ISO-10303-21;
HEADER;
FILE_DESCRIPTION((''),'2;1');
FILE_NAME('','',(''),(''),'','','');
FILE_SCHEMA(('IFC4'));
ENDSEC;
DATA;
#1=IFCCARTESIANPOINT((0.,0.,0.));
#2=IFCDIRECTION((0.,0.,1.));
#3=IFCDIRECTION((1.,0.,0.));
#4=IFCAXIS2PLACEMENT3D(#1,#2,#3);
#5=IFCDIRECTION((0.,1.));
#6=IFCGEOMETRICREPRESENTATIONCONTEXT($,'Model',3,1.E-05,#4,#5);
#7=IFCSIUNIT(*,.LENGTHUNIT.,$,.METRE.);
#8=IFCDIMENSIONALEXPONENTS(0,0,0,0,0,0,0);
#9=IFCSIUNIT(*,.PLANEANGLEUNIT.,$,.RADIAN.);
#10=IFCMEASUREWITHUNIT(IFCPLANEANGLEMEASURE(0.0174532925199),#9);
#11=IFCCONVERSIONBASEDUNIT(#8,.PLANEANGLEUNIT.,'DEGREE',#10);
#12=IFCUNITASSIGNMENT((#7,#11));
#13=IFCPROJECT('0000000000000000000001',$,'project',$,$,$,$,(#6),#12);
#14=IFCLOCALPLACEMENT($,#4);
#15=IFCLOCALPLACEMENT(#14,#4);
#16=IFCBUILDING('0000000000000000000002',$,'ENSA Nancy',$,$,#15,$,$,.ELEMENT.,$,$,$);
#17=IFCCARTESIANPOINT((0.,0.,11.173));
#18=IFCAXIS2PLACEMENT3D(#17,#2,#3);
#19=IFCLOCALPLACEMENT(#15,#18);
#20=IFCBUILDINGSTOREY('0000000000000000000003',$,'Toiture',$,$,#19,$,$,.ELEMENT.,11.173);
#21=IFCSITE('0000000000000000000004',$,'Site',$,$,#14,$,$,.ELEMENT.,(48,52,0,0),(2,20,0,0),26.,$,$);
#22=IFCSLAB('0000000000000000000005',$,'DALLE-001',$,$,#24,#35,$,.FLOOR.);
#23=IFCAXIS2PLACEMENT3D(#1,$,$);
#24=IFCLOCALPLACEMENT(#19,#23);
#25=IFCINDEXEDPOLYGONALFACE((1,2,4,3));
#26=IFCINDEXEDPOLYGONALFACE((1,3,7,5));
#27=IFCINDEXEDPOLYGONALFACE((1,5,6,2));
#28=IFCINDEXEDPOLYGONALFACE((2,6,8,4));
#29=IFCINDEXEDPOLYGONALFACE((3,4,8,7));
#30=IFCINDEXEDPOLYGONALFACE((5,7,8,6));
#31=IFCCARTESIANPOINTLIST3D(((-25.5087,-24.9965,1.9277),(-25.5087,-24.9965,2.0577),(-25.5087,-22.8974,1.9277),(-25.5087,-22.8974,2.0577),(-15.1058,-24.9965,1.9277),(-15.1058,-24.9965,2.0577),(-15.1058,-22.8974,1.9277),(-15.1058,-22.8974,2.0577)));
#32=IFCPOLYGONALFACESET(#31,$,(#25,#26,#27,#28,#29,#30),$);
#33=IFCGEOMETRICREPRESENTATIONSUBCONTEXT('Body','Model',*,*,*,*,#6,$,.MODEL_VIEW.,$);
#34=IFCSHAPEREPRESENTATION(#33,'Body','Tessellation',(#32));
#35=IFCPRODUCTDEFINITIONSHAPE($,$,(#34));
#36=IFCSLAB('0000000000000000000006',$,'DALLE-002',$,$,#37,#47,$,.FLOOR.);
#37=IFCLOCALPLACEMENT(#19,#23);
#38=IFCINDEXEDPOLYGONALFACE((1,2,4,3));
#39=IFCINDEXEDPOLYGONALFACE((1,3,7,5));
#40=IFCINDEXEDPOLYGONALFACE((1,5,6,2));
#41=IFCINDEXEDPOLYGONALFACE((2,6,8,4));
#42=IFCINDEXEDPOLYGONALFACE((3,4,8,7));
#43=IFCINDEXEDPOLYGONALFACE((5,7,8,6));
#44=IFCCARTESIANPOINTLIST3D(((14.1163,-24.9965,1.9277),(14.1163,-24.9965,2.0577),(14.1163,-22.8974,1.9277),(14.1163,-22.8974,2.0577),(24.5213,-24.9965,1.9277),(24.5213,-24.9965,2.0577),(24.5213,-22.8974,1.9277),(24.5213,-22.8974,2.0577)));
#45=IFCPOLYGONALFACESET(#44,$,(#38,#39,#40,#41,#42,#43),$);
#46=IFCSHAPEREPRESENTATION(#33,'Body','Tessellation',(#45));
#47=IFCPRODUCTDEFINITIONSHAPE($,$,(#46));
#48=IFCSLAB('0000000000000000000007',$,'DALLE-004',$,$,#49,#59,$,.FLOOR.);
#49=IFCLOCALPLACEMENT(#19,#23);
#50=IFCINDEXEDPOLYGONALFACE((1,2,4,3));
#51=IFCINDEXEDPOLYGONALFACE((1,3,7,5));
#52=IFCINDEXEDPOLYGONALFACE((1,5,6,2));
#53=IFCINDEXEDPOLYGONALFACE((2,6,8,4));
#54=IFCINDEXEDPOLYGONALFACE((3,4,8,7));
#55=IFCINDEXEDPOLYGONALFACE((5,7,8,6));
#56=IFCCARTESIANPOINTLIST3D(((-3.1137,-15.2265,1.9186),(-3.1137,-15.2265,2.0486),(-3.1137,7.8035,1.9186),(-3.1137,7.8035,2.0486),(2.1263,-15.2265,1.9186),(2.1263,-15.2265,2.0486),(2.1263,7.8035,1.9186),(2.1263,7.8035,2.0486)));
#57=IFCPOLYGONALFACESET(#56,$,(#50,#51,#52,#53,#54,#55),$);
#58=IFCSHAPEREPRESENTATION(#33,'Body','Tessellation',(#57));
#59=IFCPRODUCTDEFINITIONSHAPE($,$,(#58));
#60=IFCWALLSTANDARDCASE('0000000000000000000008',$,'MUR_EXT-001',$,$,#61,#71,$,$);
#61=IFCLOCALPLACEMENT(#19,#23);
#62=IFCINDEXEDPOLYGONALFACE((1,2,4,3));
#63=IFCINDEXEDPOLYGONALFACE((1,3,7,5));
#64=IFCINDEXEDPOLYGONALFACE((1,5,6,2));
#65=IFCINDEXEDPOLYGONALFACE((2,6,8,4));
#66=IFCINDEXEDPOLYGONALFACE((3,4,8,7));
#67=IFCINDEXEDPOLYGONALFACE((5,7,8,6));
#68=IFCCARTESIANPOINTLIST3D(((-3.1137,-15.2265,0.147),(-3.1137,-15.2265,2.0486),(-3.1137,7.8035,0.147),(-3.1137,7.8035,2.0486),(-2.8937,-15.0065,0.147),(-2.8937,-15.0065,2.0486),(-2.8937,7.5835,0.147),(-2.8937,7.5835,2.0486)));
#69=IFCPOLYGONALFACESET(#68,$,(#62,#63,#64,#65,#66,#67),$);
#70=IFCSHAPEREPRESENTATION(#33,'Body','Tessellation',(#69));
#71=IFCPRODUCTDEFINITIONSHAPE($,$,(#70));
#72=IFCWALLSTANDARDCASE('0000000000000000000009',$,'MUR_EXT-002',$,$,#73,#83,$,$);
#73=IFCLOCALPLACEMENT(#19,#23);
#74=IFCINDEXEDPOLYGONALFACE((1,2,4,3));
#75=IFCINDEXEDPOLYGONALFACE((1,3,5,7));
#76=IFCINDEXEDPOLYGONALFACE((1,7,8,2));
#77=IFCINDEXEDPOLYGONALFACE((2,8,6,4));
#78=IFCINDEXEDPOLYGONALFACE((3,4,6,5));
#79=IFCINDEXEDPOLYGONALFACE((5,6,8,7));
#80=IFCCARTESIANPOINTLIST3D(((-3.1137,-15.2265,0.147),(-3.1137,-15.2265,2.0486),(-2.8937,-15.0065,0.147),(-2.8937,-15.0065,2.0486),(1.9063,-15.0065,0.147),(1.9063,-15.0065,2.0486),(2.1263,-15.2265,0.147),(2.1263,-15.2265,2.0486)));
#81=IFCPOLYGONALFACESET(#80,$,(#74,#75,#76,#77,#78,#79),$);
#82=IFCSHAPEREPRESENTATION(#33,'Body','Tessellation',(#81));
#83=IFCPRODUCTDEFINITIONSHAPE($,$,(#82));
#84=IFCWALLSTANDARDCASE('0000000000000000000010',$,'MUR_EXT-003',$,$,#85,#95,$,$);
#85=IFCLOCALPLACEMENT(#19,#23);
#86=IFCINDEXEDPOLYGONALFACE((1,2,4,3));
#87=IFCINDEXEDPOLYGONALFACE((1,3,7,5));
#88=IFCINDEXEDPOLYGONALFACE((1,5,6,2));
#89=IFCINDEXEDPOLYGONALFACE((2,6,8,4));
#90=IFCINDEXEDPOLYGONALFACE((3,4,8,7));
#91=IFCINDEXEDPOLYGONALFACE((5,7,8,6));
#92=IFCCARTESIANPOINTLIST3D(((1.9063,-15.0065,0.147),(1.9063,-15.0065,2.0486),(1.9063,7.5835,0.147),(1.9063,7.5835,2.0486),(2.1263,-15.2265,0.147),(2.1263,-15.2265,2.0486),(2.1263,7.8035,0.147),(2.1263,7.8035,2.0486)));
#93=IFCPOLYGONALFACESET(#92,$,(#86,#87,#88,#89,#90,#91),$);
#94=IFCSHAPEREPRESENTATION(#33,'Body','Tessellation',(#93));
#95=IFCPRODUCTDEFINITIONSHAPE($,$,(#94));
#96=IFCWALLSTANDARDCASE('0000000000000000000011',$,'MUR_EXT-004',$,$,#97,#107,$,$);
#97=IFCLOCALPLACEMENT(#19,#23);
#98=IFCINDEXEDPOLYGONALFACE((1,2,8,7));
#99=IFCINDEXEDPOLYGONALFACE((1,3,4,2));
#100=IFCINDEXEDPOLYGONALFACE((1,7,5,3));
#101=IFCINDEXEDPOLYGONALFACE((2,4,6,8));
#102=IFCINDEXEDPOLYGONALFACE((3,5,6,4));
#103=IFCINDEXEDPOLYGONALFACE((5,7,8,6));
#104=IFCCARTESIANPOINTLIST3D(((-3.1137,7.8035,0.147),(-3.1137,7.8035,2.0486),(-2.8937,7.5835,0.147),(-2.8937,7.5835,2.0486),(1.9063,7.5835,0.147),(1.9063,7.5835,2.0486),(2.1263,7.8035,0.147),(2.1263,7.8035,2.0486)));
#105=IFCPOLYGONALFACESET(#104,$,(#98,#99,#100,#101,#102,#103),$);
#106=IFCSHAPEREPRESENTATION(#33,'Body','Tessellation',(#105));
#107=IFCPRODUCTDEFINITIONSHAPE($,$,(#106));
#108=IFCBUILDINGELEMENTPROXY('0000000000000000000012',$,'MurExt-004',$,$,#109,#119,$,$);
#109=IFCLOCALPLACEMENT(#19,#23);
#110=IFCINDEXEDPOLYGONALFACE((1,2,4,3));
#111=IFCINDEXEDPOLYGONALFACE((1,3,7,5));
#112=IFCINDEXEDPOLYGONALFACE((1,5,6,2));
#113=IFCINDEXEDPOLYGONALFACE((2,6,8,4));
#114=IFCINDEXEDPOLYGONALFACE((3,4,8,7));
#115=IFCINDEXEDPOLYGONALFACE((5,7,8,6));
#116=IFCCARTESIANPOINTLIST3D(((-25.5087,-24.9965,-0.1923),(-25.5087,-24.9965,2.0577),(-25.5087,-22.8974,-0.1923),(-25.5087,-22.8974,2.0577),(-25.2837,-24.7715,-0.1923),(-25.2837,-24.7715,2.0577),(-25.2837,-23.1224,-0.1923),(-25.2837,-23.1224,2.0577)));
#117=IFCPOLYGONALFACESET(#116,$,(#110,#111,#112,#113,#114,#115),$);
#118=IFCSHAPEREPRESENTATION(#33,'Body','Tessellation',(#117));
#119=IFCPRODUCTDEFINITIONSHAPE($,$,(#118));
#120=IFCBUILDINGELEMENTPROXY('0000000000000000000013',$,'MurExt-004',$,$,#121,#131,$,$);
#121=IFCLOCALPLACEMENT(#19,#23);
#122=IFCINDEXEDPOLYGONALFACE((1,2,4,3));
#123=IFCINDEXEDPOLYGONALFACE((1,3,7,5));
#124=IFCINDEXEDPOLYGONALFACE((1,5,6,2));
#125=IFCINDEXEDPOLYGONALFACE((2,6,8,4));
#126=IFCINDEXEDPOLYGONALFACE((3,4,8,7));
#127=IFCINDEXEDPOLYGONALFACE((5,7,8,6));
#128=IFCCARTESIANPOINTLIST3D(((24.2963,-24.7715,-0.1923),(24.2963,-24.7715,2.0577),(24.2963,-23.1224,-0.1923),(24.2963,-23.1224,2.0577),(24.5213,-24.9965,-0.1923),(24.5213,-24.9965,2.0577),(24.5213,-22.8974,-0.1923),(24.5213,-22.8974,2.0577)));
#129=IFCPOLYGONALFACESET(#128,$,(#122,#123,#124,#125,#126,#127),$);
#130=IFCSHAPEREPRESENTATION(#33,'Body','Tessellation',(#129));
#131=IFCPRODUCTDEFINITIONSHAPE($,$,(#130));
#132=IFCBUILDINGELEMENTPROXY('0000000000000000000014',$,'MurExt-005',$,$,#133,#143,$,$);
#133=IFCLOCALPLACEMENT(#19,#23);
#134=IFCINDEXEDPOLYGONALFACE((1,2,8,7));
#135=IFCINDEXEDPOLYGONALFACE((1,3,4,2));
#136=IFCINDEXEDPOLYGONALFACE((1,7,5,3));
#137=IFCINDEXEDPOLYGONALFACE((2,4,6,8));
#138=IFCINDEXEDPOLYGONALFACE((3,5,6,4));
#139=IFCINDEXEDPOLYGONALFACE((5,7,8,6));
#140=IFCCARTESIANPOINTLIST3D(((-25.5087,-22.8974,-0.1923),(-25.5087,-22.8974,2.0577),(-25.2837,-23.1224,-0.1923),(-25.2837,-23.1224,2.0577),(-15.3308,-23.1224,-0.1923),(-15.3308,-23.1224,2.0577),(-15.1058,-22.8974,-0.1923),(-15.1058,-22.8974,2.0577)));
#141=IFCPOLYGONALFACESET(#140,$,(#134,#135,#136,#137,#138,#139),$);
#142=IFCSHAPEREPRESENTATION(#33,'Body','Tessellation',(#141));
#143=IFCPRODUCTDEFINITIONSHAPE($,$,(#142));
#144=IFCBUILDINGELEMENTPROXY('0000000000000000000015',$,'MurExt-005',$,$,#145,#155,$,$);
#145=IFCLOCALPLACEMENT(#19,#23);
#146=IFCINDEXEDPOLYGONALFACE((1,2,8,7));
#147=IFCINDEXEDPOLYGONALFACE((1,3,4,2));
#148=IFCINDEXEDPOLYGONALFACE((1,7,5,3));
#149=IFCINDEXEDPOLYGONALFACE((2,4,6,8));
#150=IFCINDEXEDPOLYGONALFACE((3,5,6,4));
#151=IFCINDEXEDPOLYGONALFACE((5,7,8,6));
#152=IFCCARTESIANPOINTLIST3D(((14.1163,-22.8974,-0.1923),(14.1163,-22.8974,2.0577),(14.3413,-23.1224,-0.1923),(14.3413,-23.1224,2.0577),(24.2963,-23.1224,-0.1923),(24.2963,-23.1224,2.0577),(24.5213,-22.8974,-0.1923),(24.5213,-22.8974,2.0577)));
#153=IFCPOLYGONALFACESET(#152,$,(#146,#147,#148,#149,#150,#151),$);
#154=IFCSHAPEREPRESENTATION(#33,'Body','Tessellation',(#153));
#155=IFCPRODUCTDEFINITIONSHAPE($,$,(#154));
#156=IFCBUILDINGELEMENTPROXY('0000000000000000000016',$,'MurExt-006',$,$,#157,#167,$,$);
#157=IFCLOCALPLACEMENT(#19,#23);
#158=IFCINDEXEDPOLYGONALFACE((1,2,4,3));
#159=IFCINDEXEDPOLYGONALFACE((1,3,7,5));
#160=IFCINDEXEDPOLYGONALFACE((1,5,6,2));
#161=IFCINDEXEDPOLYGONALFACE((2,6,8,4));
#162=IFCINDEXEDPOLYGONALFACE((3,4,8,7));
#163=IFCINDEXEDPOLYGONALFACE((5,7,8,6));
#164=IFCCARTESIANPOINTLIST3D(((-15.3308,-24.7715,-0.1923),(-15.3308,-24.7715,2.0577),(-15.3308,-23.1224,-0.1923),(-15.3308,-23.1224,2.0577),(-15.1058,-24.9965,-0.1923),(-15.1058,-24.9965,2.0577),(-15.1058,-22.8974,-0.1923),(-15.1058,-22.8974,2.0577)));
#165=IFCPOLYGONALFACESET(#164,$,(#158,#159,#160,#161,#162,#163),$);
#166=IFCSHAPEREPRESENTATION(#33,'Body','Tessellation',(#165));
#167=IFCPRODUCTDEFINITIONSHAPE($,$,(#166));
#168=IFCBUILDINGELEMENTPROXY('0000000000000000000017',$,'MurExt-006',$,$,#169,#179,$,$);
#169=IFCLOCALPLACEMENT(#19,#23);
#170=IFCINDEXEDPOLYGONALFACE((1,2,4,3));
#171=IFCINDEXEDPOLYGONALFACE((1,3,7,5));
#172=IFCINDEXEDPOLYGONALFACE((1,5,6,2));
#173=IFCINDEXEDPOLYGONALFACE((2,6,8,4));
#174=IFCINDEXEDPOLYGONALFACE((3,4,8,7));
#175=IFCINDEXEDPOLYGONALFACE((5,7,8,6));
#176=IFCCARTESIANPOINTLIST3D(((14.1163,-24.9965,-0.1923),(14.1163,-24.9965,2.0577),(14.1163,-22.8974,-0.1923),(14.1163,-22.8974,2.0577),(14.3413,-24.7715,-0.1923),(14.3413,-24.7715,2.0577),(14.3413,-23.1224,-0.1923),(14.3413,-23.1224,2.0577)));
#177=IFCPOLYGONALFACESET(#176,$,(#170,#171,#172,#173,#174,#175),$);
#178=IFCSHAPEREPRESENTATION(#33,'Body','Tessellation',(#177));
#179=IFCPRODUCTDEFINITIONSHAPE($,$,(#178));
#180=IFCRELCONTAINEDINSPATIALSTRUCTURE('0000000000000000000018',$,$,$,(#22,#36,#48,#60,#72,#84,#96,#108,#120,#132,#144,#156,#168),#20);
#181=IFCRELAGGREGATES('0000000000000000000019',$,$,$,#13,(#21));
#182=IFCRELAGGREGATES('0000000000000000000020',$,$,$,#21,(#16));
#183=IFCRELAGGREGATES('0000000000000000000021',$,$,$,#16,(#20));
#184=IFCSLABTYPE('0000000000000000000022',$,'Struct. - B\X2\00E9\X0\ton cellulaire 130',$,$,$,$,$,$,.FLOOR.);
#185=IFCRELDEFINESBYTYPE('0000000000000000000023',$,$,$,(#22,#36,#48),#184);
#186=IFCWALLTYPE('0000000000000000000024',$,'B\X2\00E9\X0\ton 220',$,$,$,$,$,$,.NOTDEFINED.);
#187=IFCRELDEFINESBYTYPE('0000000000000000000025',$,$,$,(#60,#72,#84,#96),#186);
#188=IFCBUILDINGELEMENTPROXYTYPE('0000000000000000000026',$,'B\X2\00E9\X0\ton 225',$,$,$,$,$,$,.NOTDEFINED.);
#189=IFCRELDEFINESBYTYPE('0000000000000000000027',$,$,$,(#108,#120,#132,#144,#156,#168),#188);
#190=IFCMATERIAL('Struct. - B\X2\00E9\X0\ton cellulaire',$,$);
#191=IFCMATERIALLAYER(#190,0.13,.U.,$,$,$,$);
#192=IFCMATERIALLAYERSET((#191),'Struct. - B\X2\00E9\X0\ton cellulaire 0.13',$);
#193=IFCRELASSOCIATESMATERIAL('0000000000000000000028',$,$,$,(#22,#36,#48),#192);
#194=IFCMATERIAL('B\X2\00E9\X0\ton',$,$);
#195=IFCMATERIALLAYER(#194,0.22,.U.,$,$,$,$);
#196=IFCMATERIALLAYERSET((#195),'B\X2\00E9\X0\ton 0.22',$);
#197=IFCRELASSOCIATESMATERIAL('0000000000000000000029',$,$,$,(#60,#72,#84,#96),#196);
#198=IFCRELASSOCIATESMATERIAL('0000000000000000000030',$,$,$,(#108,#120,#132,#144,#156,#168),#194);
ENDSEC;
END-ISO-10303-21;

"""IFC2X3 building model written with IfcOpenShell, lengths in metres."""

from ifc_helpers import new_model, entity, si_unit, converted_unit, direction, frame, origin_with_axes, place, context, subcontext, project, spatial, polyline, outline, extrude, material, layer, layer_set, layer_usage, type_object, element, save


model = new_model("IFC2X3")

# Units and contexts
model_context = context("Model", 3, precision=1e-05, world=origin_with_axes(), true_north=direction((0.0, 1.0)))
body_context = subcontext(model_context, "Body", "Model", "MODEL_VIEW")
ifc_project = project(units=[si_unit("LENGTHUNIT", "METRE"), converted_unit("PLANEANGLEUNIT", "DEGREE", entity("IfcPlaneAngleMeasure", 0.0174532925199), si_unit("PLANEANGLEUNIT", "RADIAN"), dimensions=[0, 0, 0, 0, 0, 0, 0])], contexts=[model_context])

# Site, building, storey
site_placement = place(None, origin_with_axes())
site = spatial("IfcSite", under=ifc_project, at=site_placement, Name="Site", CompositionType="ELEMENT", RefLatitude=(48, 52, 0, 0), RefLongitude=(2, 20, 0, 0), RefElevation=26.0)
building_placement = place(site_placement, origin_with_axes())
building = spatial("IfcBuilding", under=site, at=building_placement, Name="ENSA Nancy", CompositionType="ELEMENT")
storey_placement = place(building_placement, frame((0.0, 0.0, 11.173), z_axis=(0.0, 0.0, 1.0), x_axis=(1.0, 0.0, 0.0)))
storey = spatial("IfcBuildingStorey", under=building, at=storey_placement, Name="Toiture", CompositionType="ELEMENT", Elevation=11.173)

# Slabs
ifc_material_1 = material(Name="Struct. - Béton cellulaire")
ifc_layer_1 = layer(ifc_material_1, 0.13, ventilated="UNKNOWN")
ifc_layer_set_1 = layer_set([ifc_layer_1], Name="Struct. - Béton cellulaire 0.13")
ifc_layer_usage_1 = layer_usage(ifc_layer_set_1, "AXIS3", "NEGATIVE", 0.13)
slab_type = type_object("IfcSlabType", Name="Struct. - Béton cellulaire 130", PredefinedType="FLOOR")
slab_1_placement = place(storey_placement, frame((-25.5087, -24.9965, 2.0577), z_axis=(0.0, 0.0, 1.0), x_axis=(1.0, 0.0, 0.0)))
element("IfcSlab", 1, at=slab_1_placement, inside=storey, type_object=slab_type, material=ifc_layer_usage_1, Name="DALLE-001", PredefinedType="FLOOR", context=body_context, shape_type="SweptSolid", body=[
    extrude(outline(polyline([(0.0, 0.0), (10.4029, 0.0), (10.4029, 2.0992), (0.0, 2.0992), (0.0, 0.0)])), frame((0.0, 0.0, -0.13), z_axis=(0.0, 0.0, 1.0), x_axis=(1.0, 0.0, 0.0)), (0.0, 0.0, 1.0), 0.13),
])
ifc_layer_usage_2 = layer_usage(ifc_layer_set_1, "AXIS3", "NEGATIVE", 0.13)
slab_2_placement = place(storey_placement, frame((14.1163, -24.9965, 2.0577), z_axis=(0.0, 0.0, 1.0), x_axis=(1.0, 0.0, 0.0)))
element("IfcSlab", 2, at=slab_2_placement, inside=storey, type_object=slab_type, material=ifc_layer_usage_2, Name="DALLE-002", PredefinedType="FLOOR", context=body_context, shape_type="SweptSolid", body=[
    extrude(outline(polyline([(0.0, 0.0), (10.405, 0.0), (10.405, 2.0992), (0.0, 2.0992), (0.0, 0.0)])), frame((0.0, 0.0, -0.13), z_axis=(0.0, 0.0, 1.0), x_axis=(1.0, 0.0, 0.0)), (0.0, 0.0, 1.0), 0.13),
])
ifc_layer_usage_3 = layer_usage(ifc_layer_set_1, "AXIS3", "NEGATIVE", 0.13)
slab_3_placement = place(storey_placement, frame((-3.1137, -15.2265, 2.0486), z_axis=(0.0, 0.0, 1.0), x_axis=(1.0, 0.0, 0.0)))
element("IfcSlab", 3, at=slab_3_placement, inside=storey, type_object=slab_type, material=ifc_layer_usage_3, Name="DALLE-004", PredefinedType="FLOOR", context=body_context, shape_type="SweptSolid", body=[
    extrude(outline(polyline([(0.0, 0.0), (5.24, 0.0), (5.24, 23.03), (0.0, 23.03), (0.0, 0.0)])), frame((0.0, 0.0, -0.13), z_axis=(0.0, 0.0, 1.0), x_axis=(1.0, 0.0, 0.0)), (0.0, 0.0, 1.0), 0.13),
])

# Walls
ifc_material_2 = material(Name="Béton")
ifc_layer_2 = layer(ifc_material_2, 0.22, ventilated="UNKNOWN")
ifc_layer_set_2 = layer_set([ifc_layer_2], Name="Béton 0.22")
ifc_layer_usage_4 = layer_usage(ifc_layer_set_2, "AXIS2", "POSITIVE", 0.0)
wall_type = type_object("IfcWallType", Name="Béton 220", PredefinedType="NOTDEFINED")
wall_1_placement = place(storey_placement, frame((-3.1137, 7.8035, 0.147), z_axis=(0.0, 0.0, 1.0), x_axis=(0.0, -1.0, 0.0)))
element("IfcWallStandardCase", 4, at=wall_1_placement, inside=storey, type_object=wall_type, material=ifc_layer_usage_4, Name="MUR_EXT-001", context=body_context, shape_type="SweptSolid", body=[
    extrude(outline(polyline([(0.0, 0.0), (23.03, 0.0), (22.81, 0.22), (0.22, 0.22), (0.0, 0.0)])), origin_with_axes(), (0.0, 0.0, 1.0), 1.9016),
])
ifc_layer_usage_5 = layer_usage(ifc_layer_set_2, "AXIS2", "POSITIVE", 0.0)
wall_2_placement = place(storey_placement, frame((-3.1137, -15.2265, 0.147), z_axis=(0.0, 0.0, 1.0), x_axis=(1.0, 0.0, 0.0)))
element("IfcWallStandardCase", 5, at=wall_2_placement, inside=storey, type_object=wall_type, material=ifc_layer_usage_5, Name="MUR_EXT-002", context=body_context, shape_type="SweptSolid", body=[
    extrude(outline(polyline([(0.0, 0.0), (5.24, 0.0), (5.02, 0.22), (0.22, 0.22), (0.0, 0.0)])), origin_with_axes(), (0.0, 0.0, 1.0), 1.9016),
])
ifc_layer_usage_6 = layer_usage(ifc_layer_set_2, "AXIS2", "POSITIVE", 0.0)
wall_3_placement = place(storey_placement, frame((2.1263, -15.2265, 0.147), z_axis=(0.0, 0.0, 1.0), x_axis=(0.0, 1.0, 0.0)))
element("IfcWallStandardCase", 6, at=wall_3_placement, inside=storey, type_object=wall_type, material=ifc_layer_usage_6, Name="MUR_EXT-003", context=body_context, shape_type="SweptSolid", body=[
    extrude(outline(polyline([(0.0, 0.0), (23.03, 0.0), (22.81, 0.22), (0.22, 0.22), (0.0, 0.0)])), origin_with_axes(), (0.0, 0.0, 1.0), 1.9016),
])
ifc_layer_usage_7 = layer_usage(ifc_layer_set_2, "AXIS2", "POSITIVE", 0.0)
wall_4_placement = place(storey_placement, frame((2.1263, 7.8035, 0.147), z_axis=(0.0, 0.0, 1.0), x_axis=(-1.0, 0.0, 0.0)))
element("IfcWallStandardCase", 7, at=wall_4_placement, inside=storey, type_object=wall_type, material=ifc_layer_usage_7, Name="MUR_EXT-004", context=body_context, shape_type="SweptSolid", body=[
    extrude(outline(polyline([(0.0, 0.0), (5.24, 0.0), (5.02, 0.22), (0.22, 0.22), (0.0, 0.0)])), origin_with_axes(), (0.0, 0.0, 1.0), 1.9016),
])

# Building element proxies
building_element_proxy_type = type_object("IfcBuildingElementProxyType", Name="Béton 225", PredefinedType="NOTDEFINED")
proxy_1_placement = place(storey_placement, frame((-25.5087, -24.9965, -0.1923), z_axis=(0.0, 0.0, 1.0), x_axis=(0.0, 1.0, 0.0)))
element("IfcBuildingElementProxy", 8, at=proxy_1_placement, inside=storey, type_object=building_element_proxy_type, material=ifc_material_2, Name="MurExt-004", context=body_context, shape_type="SweptSolid", body=[
    extrude(outline(polyline([(0.225, -0.225), (1.8742, -0.225), (2.0992, 0.0), (0.0, 0.0), (0.225, -0.225)])), origin_with_axes(), (0.0, 0.0, 1.0), 2.25),
])
proxy_2_placement = place(storey_placement, frame((24.5213, -24.9965, -0.1923), z_axis=(0.0, 0.0, 1.0), x_axis=(0.0, 1.0, 0.0)))
element("IfcBuildingElementProxy", 9, at=proxy_2_placement, inside=storey, type_object=building_element_proxy_type, material=ifc_material_2, Name="MurExt-004", context=body_context, shape_type="SweptSolid", body=[
    extrude(outline(polyline([(0.0, 0.0), (2.0992, 0.0), (1.8742, 0.225), (0.225, 0.225), (0.0, 0.0)])), origin_with_axes(), (0.0, 0.0, 1.0), 2.25),
])
proxy_3_placement = place(storey_placement, frame((-25.5087, -22.8974, -0.1923), z_axis=(0.0, 0.0, 1.0), x_axis=(1.0, 0.0, 0.0)))
element("IfcBuildingElementProxy", 10, at=proxy_3_placement, inside=storey, type_object=building_element_proxy_type, material=ifc_material_2, Name="MurExt-005", context=body_context, shape_type="SweptSolid", body=[
    extrude(outline(polyline([(0.225, -0.225), (10.1779, -0.225), (10.4029, 0.0), (0.0, 0.0), (0.225, -0.225)])), origin_with_axes(), (0.0, 0.0, 1.0), 2.25),
])
proxy_4_placement = place(storey_placement, frame((24.5213, -22.8974, -0.1923), z_axis=(0.0, 0.0, 1.0), x_axis=(-1.0, 0.0, 0.0)))
element("IfcBuildingElementProxy", 11, at=proxy_4_placement, inside=storey, type_object=building_element_proxy_type, material=ifc_material_2, Name="MurExt-005", context=body_context, shape_type="SweptSolid", body=[
    extrude(outline(polyline([(0.0, 0.0), (10.405, 0.0), (10.18, 0.225), (0.225, 0.225), (0.0, 0.0)])), origin_with_axes(), (0.0, 0.0, 1.0), 2.25),
])
proxy_5_placement = place(storey_placement, frame((-15.1058, -22.8974, -0.1923), z_axis=(0.0, 0.0, 1.0), x_axis=(0.0, -1.0, 0.0)))
element("IfcBuildingElementProxy", 12, at=proxy_5_placement, inside=storey, type_object=building_element_proxy_type, material=ifc_material_2, Name="MurExt-006", context=body_context, shape_type="SweptSolid", body=[
    extrude(outline(polyline([(0.225, -0.225), (1.8742, -0.225), (2.0992, 0.0), (0.0, 0.0), (0.225, -0.225)])), origin_with_axes(), (0.0, 0.0, 1.0), 2.25),
])
proxy_6_placement = place(storey_placement, frame((14.1163, -22.8974, -0.1923), z_axis=(0.0, 0.0, 1.0), x_axis=(0.0, -1.0, 0.0)))
element("IfcBuildingElementProxy", 13, at=proxy_6_placement, inside=storey, type_object=building_element_proxy_type, material=ifc_material_2, Name="MurExt-006", context=body_context, shape_type="SweptSolid", body=[
    extrude(outline(polyline([(0.0, 0.0), (2.0992, 0.0), (1.8742, 0.225), (0.225, 0.225), (0.0, 0.0)])), origin_with_axes(), (0.0, 0.0, 1.0), 2.25),
])

save(model, "model.ifc")
